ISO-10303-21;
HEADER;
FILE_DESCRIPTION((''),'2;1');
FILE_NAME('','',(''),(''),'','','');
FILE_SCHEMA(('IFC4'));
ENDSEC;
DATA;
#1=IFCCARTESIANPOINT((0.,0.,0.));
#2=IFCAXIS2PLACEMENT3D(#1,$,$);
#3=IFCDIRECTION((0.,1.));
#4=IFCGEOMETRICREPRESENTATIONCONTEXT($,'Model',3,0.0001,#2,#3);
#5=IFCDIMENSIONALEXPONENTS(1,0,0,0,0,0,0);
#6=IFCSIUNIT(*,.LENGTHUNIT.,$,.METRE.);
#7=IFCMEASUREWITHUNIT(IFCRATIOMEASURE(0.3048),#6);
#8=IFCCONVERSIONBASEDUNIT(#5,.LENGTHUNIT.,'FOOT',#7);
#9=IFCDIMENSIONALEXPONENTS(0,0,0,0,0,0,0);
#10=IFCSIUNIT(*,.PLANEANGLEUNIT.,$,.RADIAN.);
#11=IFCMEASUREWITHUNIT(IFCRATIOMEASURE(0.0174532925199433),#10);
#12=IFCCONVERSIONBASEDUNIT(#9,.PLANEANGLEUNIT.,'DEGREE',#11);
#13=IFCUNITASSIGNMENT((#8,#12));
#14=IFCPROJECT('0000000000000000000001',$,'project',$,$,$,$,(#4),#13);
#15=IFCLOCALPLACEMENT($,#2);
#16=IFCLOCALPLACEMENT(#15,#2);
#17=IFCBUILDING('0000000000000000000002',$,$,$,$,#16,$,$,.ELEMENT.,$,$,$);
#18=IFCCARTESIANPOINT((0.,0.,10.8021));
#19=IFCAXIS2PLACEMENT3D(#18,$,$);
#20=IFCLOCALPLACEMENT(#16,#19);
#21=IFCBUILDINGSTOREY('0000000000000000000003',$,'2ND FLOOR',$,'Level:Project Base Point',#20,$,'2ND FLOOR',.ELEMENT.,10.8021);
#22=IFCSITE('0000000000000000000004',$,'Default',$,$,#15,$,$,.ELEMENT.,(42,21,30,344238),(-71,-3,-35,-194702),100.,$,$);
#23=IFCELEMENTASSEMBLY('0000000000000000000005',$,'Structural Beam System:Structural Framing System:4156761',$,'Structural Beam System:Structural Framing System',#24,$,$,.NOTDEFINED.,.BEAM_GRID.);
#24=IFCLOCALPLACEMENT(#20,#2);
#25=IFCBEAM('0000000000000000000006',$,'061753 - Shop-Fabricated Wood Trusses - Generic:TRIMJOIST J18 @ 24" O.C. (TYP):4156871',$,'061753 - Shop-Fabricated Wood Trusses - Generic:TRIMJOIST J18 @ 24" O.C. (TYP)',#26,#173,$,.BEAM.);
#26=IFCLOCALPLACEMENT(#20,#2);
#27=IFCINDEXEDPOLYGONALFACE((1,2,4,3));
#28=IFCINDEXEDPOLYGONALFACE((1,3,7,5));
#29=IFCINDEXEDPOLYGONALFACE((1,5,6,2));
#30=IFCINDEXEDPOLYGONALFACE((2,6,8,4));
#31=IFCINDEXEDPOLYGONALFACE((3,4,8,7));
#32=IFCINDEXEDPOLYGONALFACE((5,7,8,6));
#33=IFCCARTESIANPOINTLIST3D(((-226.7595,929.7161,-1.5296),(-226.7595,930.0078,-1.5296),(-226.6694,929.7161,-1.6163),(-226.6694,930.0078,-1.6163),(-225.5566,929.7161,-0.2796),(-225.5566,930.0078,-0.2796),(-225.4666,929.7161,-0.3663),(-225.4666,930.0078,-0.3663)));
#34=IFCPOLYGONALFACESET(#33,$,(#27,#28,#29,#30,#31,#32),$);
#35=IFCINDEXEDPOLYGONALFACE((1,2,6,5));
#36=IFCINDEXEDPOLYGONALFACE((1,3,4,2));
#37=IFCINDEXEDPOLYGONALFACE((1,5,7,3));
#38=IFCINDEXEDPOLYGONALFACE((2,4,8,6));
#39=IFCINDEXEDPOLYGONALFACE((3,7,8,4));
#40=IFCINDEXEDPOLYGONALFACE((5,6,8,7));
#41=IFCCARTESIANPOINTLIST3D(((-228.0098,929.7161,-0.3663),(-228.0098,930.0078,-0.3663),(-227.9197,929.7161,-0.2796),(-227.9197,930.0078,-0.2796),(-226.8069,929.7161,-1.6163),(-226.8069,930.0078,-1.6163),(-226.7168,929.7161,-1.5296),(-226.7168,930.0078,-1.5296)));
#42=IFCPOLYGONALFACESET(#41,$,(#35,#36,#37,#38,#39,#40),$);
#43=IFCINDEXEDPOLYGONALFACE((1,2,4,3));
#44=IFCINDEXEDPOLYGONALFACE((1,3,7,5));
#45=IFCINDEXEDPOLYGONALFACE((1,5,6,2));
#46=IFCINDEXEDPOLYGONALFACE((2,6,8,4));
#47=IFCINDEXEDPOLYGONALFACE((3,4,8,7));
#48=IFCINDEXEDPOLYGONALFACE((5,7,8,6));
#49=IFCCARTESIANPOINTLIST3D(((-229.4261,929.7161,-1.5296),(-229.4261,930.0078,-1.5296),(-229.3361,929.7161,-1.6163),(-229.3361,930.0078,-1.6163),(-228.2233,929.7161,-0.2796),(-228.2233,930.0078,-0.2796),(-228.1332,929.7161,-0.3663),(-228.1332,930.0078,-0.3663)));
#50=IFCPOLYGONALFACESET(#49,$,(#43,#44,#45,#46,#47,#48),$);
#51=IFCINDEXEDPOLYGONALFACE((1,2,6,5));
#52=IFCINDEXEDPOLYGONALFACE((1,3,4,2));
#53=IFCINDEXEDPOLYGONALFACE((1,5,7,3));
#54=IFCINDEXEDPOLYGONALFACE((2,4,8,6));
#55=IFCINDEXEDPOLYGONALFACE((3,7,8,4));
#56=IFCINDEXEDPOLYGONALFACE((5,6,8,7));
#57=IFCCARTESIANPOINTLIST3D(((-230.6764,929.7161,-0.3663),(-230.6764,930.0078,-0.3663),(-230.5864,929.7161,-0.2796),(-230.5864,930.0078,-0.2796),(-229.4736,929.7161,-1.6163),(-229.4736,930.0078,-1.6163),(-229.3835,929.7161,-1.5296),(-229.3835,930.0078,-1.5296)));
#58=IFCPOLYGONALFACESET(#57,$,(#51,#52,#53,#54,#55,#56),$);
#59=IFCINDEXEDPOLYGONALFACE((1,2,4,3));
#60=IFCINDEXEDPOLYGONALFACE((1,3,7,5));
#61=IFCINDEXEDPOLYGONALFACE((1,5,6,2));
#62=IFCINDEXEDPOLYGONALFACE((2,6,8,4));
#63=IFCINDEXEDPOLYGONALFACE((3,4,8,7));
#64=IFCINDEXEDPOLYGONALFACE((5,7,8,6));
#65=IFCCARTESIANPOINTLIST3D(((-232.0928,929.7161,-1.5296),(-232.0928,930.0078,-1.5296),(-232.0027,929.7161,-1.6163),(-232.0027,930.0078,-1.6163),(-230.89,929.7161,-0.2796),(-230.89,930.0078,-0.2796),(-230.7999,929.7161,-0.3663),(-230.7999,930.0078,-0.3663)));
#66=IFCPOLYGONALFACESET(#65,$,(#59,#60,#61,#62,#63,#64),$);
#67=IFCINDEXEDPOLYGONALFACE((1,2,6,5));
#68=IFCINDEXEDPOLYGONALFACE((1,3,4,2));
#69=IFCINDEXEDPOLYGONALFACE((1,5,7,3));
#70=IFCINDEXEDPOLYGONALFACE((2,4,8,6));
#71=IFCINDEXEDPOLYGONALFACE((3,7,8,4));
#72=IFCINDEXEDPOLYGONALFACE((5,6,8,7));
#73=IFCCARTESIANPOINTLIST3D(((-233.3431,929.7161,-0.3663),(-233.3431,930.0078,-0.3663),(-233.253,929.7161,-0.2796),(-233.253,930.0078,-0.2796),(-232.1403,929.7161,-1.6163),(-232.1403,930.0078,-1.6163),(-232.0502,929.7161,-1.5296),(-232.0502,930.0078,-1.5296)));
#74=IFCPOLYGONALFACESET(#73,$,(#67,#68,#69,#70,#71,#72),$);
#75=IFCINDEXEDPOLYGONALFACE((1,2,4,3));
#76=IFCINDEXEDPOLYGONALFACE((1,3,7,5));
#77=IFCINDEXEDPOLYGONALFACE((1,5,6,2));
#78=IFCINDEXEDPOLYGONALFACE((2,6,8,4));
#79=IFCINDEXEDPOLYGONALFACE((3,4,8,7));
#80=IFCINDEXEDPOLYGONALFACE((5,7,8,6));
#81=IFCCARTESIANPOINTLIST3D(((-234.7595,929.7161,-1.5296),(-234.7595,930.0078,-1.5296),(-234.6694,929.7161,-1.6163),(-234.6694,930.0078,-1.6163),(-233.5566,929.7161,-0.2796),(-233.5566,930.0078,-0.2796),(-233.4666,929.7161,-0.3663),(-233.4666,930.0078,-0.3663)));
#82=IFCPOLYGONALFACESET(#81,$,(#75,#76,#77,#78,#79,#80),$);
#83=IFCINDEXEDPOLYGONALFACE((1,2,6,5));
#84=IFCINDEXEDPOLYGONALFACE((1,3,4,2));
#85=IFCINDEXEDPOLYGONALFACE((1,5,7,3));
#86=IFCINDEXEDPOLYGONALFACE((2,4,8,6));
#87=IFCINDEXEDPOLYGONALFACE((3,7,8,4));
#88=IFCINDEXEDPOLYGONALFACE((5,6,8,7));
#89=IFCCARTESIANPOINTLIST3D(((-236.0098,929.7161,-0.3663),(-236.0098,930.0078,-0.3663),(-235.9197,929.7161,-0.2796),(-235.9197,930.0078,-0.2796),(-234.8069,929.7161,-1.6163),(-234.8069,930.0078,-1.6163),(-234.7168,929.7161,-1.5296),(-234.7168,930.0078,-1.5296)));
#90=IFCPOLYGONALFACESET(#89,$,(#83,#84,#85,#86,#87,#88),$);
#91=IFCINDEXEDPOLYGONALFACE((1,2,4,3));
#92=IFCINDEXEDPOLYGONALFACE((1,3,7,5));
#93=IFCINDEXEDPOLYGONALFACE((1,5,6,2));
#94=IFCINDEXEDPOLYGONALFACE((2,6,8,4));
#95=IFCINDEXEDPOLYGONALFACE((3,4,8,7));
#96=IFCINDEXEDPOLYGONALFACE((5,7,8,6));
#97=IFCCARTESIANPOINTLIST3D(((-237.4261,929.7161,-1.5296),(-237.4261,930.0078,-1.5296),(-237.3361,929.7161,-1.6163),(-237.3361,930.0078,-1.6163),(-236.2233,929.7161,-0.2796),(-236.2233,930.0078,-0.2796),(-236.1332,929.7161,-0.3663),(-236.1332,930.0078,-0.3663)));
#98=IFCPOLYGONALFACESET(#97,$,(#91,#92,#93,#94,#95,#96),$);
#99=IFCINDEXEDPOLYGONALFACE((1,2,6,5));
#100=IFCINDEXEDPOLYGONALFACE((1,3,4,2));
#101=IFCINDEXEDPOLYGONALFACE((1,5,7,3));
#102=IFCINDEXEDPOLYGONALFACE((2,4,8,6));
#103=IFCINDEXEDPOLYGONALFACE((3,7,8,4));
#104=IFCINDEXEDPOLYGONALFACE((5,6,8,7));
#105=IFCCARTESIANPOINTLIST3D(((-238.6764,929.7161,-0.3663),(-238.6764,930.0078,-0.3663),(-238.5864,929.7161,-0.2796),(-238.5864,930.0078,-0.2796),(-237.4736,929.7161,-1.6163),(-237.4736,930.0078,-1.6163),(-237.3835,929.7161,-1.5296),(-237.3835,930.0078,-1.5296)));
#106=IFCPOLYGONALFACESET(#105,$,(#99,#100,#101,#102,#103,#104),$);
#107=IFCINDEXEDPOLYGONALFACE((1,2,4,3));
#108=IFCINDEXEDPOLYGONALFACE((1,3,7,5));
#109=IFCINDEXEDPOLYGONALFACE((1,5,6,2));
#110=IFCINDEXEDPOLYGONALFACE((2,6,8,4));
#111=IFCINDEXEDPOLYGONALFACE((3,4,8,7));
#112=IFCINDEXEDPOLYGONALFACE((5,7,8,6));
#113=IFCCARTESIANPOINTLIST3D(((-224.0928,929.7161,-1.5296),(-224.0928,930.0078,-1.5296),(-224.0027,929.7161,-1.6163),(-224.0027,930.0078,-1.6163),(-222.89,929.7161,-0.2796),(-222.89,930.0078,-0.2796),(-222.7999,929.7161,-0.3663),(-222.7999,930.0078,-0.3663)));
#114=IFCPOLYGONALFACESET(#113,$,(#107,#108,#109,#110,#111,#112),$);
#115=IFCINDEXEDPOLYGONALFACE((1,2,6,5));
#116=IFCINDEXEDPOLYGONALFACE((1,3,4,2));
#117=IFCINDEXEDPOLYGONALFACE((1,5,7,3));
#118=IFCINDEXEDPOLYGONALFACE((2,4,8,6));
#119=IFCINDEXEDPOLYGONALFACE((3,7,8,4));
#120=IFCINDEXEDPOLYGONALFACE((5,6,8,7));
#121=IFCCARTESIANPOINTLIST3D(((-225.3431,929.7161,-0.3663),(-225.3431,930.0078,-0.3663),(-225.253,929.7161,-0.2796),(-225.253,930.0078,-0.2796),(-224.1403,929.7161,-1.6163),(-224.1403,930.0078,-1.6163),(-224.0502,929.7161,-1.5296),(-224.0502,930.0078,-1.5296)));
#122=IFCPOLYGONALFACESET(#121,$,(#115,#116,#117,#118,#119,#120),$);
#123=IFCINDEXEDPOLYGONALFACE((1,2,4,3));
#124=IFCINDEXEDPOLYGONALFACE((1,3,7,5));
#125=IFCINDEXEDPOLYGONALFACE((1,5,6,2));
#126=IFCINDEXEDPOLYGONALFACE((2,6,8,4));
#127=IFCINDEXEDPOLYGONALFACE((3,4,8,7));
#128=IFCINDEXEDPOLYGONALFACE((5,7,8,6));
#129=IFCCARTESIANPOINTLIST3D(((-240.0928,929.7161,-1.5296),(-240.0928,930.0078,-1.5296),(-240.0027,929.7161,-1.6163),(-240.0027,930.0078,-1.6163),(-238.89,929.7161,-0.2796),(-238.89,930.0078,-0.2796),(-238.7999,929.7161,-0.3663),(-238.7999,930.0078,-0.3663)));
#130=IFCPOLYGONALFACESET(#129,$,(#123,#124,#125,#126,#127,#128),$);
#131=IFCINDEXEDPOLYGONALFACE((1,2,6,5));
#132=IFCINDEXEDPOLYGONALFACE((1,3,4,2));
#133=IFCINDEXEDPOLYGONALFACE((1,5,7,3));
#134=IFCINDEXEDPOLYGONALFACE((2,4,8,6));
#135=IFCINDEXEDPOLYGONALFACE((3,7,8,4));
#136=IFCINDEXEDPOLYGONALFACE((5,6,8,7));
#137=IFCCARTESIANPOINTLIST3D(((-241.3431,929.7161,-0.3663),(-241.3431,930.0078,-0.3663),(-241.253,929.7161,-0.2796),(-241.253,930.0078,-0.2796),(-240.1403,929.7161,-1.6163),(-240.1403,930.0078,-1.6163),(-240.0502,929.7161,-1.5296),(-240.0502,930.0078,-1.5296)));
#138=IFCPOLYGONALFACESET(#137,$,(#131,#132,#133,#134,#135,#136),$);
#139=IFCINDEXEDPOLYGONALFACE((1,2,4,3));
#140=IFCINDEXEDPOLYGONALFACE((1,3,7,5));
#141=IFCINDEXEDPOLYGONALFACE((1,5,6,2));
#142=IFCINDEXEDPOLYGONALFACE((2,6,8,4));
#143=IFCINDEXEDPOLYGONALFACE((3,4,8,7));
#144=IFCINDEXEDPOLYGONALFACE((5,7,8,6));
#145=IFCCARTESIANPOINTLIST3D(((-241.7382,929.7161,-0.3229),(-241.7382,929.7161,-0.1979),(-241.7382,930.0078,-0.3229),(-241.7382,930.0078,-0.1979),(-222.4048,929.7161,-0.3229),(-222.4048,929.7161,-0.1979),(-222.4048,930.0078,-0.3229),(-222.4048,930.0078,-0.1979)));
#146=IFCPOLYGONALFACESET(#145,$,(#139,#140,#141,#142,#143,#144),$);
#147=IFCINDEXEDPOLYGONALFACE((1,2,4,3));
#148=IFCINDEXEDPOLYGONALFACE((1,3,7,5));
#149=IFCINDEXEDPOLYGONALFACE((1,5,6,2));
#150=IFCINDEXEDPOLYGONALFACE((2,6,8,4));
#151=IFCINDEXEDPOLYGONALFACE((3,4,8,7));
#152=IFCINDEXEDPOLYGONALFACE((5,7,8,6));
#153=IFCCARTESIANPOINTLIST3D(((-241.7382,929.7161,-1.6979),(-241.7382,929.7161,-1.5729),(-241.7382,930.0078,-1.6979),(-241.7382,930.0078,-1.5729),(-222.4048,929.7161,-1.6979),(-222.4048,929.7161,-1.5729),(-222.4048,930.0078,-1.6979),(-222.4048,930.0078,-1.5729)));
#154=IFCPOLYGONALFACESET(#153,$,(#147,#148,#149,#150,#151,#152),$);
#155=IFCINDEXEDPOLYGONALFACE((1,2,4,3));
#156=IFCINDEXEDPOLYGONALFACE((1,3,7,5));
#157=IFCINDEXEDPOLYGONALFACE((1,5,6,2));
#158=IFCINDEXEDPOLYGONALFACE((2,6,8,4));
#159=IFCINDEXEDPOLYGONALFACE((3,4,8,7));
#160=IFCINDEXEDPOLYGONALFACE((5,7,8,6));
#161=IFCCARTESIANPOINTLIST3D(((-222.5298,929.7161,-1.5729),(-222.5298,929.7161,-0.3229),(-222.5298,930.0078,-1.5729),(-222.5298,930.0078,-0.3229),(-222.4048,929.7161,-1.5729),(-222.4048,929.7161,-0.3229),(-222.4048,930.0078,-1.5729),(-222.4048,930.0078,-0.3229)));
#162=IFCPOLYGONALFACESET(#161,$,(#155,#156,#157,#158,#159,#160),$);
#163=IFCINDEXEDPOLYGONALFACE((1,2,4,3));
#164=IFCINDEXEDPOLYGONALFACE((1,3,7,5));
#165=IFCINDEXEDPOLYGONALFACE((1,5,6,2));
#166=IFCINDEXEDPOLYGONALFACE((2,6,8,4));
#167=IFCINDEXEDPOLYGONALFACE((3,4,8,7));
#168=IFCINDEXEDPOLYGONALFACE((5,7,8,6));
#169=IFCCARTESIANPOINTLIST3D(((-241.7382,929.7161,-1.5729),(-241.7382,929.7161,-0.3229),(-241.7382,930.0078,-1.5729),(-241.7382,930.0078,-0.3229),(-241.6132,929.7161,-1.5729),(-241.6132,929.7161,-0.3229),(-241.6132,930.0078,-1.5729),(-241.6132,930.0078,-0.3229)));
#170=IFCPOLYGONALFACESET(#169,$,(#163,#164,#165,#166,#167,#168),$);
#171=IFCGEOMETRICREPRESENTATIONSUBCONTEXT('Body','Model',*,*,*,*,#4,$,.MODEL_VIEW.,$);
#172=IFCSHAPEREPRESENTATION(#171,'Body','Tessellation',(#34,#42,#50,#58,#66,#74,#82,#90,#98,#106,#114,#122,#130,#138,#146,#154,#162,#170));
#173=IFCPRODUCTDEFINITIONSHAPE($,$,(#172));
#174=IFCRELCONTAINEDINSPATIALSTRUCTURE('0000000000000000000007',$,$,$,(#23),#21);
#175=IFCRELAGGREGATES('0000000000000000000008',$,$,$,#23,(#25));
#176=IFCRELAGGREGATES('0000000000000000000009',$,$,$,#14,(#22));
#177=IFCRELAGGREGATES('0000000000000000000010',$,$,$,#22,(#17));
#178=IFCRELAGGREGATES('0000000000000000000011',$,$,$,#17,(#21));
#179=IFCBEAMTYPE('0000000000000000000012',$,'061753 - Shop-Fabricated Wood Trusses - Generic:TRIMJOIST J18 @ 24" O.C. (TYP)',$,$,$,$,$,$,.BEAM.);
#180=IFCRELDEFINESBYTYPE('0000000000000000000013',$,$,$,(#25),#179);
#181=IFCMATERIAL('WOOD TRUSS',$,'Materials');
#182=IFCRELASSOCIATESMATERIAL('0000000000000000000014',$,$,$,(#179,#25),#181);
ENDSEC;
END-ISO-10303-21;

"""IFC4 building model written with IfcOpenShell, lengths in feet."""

from ifc_helpers import new_model, entity, si_unit, converted_unit, direction, frame, frame_2d, origin, origin_2d_with_axis, place, context, subcontext, project, spatial, rectangle, extrude, source, transform, mapped, material, material_profile, profile_set, profile_usage, type_object, type_shapes, element, aggregate, save


model = new_model("IFC4")

# Units and contexts
model_context = context("Model", 3, precision=0.0001, world=origin(), true_north=direction((0.0, 1.0)))
body_context = subcontext(model_context, "Body", "Model", "MODEL_VIEW")
ifc_project = project(units=[converted_unit("LENGTHUNIT", "FOOT", entity("IfcRatioMeasure", 0.3048), si_unit("LENGTHUNIT", "METRE"), dimensions=[1, 0, 0, 0, 0, 0, 0]), converted_unit("PLANEANGLEUNIT", "DEGREE", entity("IfcRatioMeasure", 0.0174532925199433), si_unit("PLANEANGLEUNIT", "RADIAN"), dimensions=[0, 0, 0, 0, 0, 0, 0])], contexts=[model_context])

# Site, building, storey
site_placement = place(None, origin())
site = spatial("IfcSite", under=ifc_project, at=site_placement, Name="Default", CompositionType="ELEMENT", RefLatitude=(42, 21, 30, 344238), RefLongitude=(-71, -3, -35, -194702), RefElevation=100.0)
building_placement = place(site_placement, origin())
building = spatial("IfcBuilding", under=site, at=building_placement, CompositionType="ELEMENT")
storey_placement = place(building_placement, frame((0.0, 0.0, 10.8021)))
storey = spatial("IfcBuildingStorey", under=building, at=storey_placement, Name="2ND FLOOR", ObjectType="Level:Project Base Point", LongName="2ND FLOOR", CompositionType="ELEMENT", Elevation=10.8021)

# Element assembly, beam
ifc_material_1 = material(Name="WOOD TRUSS", Category="Materials")
ifc_material_profile_1 = material_profile(ifc_material_1, rectangle(XDim=1.7347, YDim=0.125, at=frame_2d((0.0, 0.0), x_axis=(1.0, 0.0))), Name="TRIMJOIST J18 @ 24\" O.C. (TYP)")
ifc_material_profile_2 = material_profile(ifc_material_1, rectangle(XDim=1.7347, YDim=0.125, at=frame_2d((0.0, 0.0), x_axis=(1.0, 0.0))), Name="TRIMJOIST J18 @ 24\" O.C. (TYP)")
ifc_material_profile_3 = material_profile(ifc_material_1, rectangle(XDim=1.7347, YDim=0.125, at=frame_2d((0.0, 0.0), x_axis=(1.0, 0.0))), Name="TRIMJOIST J18 @ 24\" O.C. (TYP)")
ifc_material_profile_4 = material_profile(ifc_material_1, rectangle(XDim=1.7347, YDim=0.125, at=frame_2d((0.0, 0.0), x_axis=(1.0, 0.0))), Name="TRIMJOIST J18 @ 24\" O.C. (TYP)")
ifc_material_profile_5 = material_profile(ifc_material_1, rectangle(XDim=1.7347, YDim=0.125, at=frame_2d((0.0, 0.0), x_axis=(1.0, 0.0))), Name="TRIMJOIST J18 @ 24\" O.C. (TYP)")
ifc_material_profile_6 = material_profile(ifc_material_1, rectangle(XDim=1.7347, YDim=0.125, at=frame_2d((0.0, 0.0), x_axis=(1.0, 0.0))), Name="TRIMJOIST J18 @ 24\" O.C. (TYP)")
ifc_material_profile_7 = material_profile(ifc_material_1, rectangle(XDim=1.7347, YDim=0.125, at=frame_2d((0.0, 0.0), x_axis=(1.0, 0.0))), Name="TRIMJOIST J18 @ 24\" O.C. (TYP)")
ifc_material_profile_8 = material_profile(ifc_material_1, rectangle(XDim=1.7347, YDim=0.125, at=frame_2d((0.0, 0.0), x_axis=(1.0, 0.0))), Name="TRIMJOIST J18 @ 24\" O.C. (TYP)")
ifc_material_profile_9 = material_profile(ifc_material_1, rectangle(XDim=1.7347, YDim=0.125, at=frame_2d((0.0, 0.0), x_axis=(1.0, 0.0))), Name="TRIMJOIST J18 @ 24\" O.C. (TYP)")
ifc_material_profile_10 = material_profile(ifc_material_1, rectangle(XDim=1.7347, YDim=0.125, at=origin_2d_with_axis()), Name="TRIMJOIST J18 @ 24\" O.C. (TYP)")
ifc_material_profile_11 = material_profile(ifc_material_1, rectangle(XDim=0.125, YDim=0.2917, at=origin_2d_with_axis()), Name="TRIMJOIST J18 @ 24\" O.C. (TYP)")
ifc_material_profile_12 = material_profile(ifc_material_1, rectangle(XDim=0.125, YDim=0.2917, at=origin_2d_with_axis()), Name="TRIMJOIST J18 @ 24\" O.C. (TYP)")
ifc_material_profile_13 = material_profile(ifc_material_1, rectangle(XDim=1.25, YDim=0.2917, at=origin_2d_with_axis()), Name="TRIMJOIST J18 @ 24\" O.C. (TYP)")
ifc_material_profile_14 = material_profile(ifc_material_1, rectangle(XDim=1.25, YDim=0.2917, at=origin_2d_with_axis()), Name="TRIMJOIST J18 @ 24\" O.C. (TYP)")
ifc_profile_set_1 = profile_set([ifc_material_profile_1, ifc_material_profile_2, ifc_material_profile_3, ifc_material_profile_4, ifc_material_profile_5, ifc_material_profile_6, ifc_material_profile_7, ifc_material_profile_8, ifc_material_profile_9, ifc_material_profile_10, ifc_material_profile_11, ifc_material_profile_12, ifc_material_profile_13, ifc_material_profile_14], Name="TRIMJOIST J18 @ 24\" O.C. (TYP)")
assembly_1_placement = place(storey_placement, origin())
assembly_1 = element("IfcElementAssembly", 1, at=assembly_1_placement, inside=storey, Name="Structural Beam System:Structural Framing System:4156761", ObjectType="Structural Beam System:Structural Framing System", AssemblyPlace="NOTDEFINED", PredefinedType="BEAM_GRID")
beam_type_1 = type_object("IfcBeamType", Name="061753 - Shop-Fabricated Wood Trusses - Generic:TRIMJOIST J18 @ 24\" O.C. (TYP)", PredefinedType="BEAM", material=ifc_profile_set_1)
shared_shape_1 = source(origin(), body_context, "Body", "SweptSolid", [
    extrude(rectangle(XDim=1.7347, YDim=0.125, at=frame_2d((0.0, 0.0), x_axis=(1.0, 0.0))), frame((5.9585, -0.1458, 0.0), z_axis=(0.0, 1.0, 0.0), x_axis=(0.693383, 0.0, 0.720569)), (0.0, 0.0, 1.0), 0.2917),
    extrude(rectangle(XDim=1.7347, YDim=0.125, at=origin_2d_with_axis()), frame((4.7082, -0.1458, 0.0), z_axis=(0.0, 1.0, 0.0), x_axis=(0.693383, 0.0, -0.720569)), (0.0, 0.0, 1.0), 0.2917),
    extrude(rectangle(XDim=1.7347, YDim=0.125, at=frame_2d((0.0, 0.0), x_axis=(1.0, 0.0))), frame((3.2918, -0.1458, 0.0), z_axis=(0.0, 1.0, 0.0), x_axis=(0.693383, 0.0, 0.720569)), (0.0, 0.0, 1.0), 0.2917),
    extrude(rectangle(XDim=1.7347, YDim=0.125, at=frame_2d((0.0, 0.0), x_axis=(1.0, 0.0))), frame((2.0415, -0.1458, 0.0), z_axis=(0.0, 1.0, 0.0), x_axis=(0.693383, 0.0, -0.720569)), (0.0, 0.0, 1.0), 0.2917),
    extrude(rectangle(XDim=1.7347, YDim=0.125, at=frame_2d((0.0, 0.0), x_axis=(1.0, 0.0))), frame((0.6251, -0.1458, 0.0), z_axis=(0.0, 1.0, 0.0), x_axis=(0.693383, 0.0, 0.720569)), (0.0, 0.0, 1.0), 0.2917),
    extrude(rectangle(XDim=1.7347, YDim=0.125, at=frame_2d((0.0, 0.0), x_axis=(1.0, 0.0))), frame((-0.6251, -0.1458, 0.0), z_axis=(0.0, 1.0, 0.0), x_axis=(0.693383, 0.0, -0.720569)), (0.0, 0.0, 1.0), 0.2917),
    extrude(rectangle(XDim=1.7347, YDim=0.125, at=frame_2d((0.0, 0.0), x_axis=(1.0, 0.0))), frame((-2.0415, -0.1458, 0.0), z_axis=(0.0, 1.0, 0.0), x_axis=(0.693383, 0.0, 0.720569)), (0.0, 0.0, 1.0), 0.2917),
    extrude(rectangle(XDim=1.7347, YDim=0.125, at=origin_2d_with_axis()), frame((-3.2918, -0.1458, 0.0), z_axis=(0.0, 1.0, 0.0), x_axis=(0.693383, 0.0, -0.720569)), (0.0, 0.0, 1.0), 0.2917),
    extrude(rectangle(XDim=1.7347, YDim=0.125, at=frame_2d((0.0, 0.0), x_axis=(1.0, 0.0))), frame((-4.7082, -0.1458, 0.0), z_axis=(0.0, 1.0, 0.0), x_axis=(0.693383, 0.0, 0.720569)), (0.0, 0.0, 1.0), 0.2917),
    extrude(rectangle(XDim=1.7347, YDim=0.125, at=frame_2d((0.0, 0.0), x_axis=(1.0, 0.0))), frame((-5.9585, -0.1458, 0.0), z_axis=(0.0, 1.0, 0.0), x_axis=(0.693383, 0.0, -0.720569)), (0.0, 0.0, 1.0), 0.2917),
    extrude(rectangle(XDim=1.7347, YDim=0.125, at=frame_2d((0.0, 0.0), x_axis=(1.0, 0.0))), frame((8.6251, -0.1458, 0.0), z_axis=(0.0, 1.0, 0.0), x_axis=(0.693383, 0.0, 0.720569)), (0.0, 0.0, 1.0), 0.2917),
    extrude(rectangle(XDim=1.7347, YDim=0.125, at=origin_2d_with_axis()), frame((7.3749, -0.1458, 0.0), z_axis=(0.0, 1.0, 0.0), x_axis=(0.693383, 0.0, -0.720569)), (0.0, 0.0, 1.0), 0.2917),
    extrude(rectangle(XDim=1.7347, YDim=0.125, at=frame_2d((0.0, 0.0), x_axis=(1.0, 0.0))), frame((-7.3749, -0.1458, 0.0), z_axis=(0.0, 1.0, 0.0), x_axis=(0.693383, 0.0, 0.720569)), (0.0, 0.0, 1.0), 0.2917),
    extrude(rectangle(XDim=1.7347, YDim=0.125, at=origin_2d_with_axis()), frame((-8.6251, -0.1458, 0.0), z_axis=(0.0, 1.0, 0.0), x_axis=(0.693383, 0.0, -0.720569)), (0.0, 0.0, 1.0), 0.2917),
    extrude(rectangle(XDim=0.125, YDim=0.2917, at=origin_2d_with_axis()), frame((-9.6667, 0.0, 0.6875), z_axis=(1.0, 0.0, 0.0), x_axis=(0.0, 0.0, -1.0)), (0.0, 0.0, 1.0), 19.3333),
    extrude(rectangle(XDim=0.125, YDim=0.2917, at=origin_2d_with_axis()), frame((-9.6667, 0.0, -0.6875), z_axis=(1.0, 0.0, 0.0), x_axis=(0.0, 0.0, -1.0)), (0.0, 0.0, 1.0), 19.3333),
    extrude(rectangle(XDim=1.25, YDim=0.2917, at=origin_2d_with_axis()), frame((9.5417, 0.0, 0.0), z_axis=(1.0, 0.0, 0.0), x_axis=(0.0, 0.0, -1.0)), (0.0, 0.0, 1.0), 0.125),
    extrude(rectangle(XDim=1.25, YDim=0.2917, at=origin_2d_with_axis()), frame((-9.6667, 0.0, 0.0), z_axis=(1.0, 0.0, 0.0), x_axis=(0.0, 0.0, -1.0)), (0.0, 0.0, 1.0), 0.125),
])
type_shapes(beam_type_1, [shared_shape_1])
ifc_profile_usage_1 = profile_usage(ifc_profile_set_1, cardinal=8)
beam_1_placement = place(assembly_1_placement, frame((-232.0715, 929.8619, -0.9479)))
beam_1 = element("IfcBeam", 2, at=beam_1_placement, type_object=beam_type_1, material=ifc_profile_usage_1, Name="061753 - Shop-Fabricated Wood Trusses - Generic:TRIMJOIST J18 @ 24\" O.C. (TYP):4156871", ObjectType="061753 - Shop-Fabricated Wood Trusses - Generic:TRIMJOIST J18 @ 24\" O.C. (TYP)", PredefinedType="BEAM", context=body_context, shape_type="MappedRepresentation", body=[
    mapped(shared_shape_1, transform((0.0, 0.0, 0.0), scale=1.0)),
])
aggregate(assembly_1, [beam_1])

save(model, "model.ifc")
